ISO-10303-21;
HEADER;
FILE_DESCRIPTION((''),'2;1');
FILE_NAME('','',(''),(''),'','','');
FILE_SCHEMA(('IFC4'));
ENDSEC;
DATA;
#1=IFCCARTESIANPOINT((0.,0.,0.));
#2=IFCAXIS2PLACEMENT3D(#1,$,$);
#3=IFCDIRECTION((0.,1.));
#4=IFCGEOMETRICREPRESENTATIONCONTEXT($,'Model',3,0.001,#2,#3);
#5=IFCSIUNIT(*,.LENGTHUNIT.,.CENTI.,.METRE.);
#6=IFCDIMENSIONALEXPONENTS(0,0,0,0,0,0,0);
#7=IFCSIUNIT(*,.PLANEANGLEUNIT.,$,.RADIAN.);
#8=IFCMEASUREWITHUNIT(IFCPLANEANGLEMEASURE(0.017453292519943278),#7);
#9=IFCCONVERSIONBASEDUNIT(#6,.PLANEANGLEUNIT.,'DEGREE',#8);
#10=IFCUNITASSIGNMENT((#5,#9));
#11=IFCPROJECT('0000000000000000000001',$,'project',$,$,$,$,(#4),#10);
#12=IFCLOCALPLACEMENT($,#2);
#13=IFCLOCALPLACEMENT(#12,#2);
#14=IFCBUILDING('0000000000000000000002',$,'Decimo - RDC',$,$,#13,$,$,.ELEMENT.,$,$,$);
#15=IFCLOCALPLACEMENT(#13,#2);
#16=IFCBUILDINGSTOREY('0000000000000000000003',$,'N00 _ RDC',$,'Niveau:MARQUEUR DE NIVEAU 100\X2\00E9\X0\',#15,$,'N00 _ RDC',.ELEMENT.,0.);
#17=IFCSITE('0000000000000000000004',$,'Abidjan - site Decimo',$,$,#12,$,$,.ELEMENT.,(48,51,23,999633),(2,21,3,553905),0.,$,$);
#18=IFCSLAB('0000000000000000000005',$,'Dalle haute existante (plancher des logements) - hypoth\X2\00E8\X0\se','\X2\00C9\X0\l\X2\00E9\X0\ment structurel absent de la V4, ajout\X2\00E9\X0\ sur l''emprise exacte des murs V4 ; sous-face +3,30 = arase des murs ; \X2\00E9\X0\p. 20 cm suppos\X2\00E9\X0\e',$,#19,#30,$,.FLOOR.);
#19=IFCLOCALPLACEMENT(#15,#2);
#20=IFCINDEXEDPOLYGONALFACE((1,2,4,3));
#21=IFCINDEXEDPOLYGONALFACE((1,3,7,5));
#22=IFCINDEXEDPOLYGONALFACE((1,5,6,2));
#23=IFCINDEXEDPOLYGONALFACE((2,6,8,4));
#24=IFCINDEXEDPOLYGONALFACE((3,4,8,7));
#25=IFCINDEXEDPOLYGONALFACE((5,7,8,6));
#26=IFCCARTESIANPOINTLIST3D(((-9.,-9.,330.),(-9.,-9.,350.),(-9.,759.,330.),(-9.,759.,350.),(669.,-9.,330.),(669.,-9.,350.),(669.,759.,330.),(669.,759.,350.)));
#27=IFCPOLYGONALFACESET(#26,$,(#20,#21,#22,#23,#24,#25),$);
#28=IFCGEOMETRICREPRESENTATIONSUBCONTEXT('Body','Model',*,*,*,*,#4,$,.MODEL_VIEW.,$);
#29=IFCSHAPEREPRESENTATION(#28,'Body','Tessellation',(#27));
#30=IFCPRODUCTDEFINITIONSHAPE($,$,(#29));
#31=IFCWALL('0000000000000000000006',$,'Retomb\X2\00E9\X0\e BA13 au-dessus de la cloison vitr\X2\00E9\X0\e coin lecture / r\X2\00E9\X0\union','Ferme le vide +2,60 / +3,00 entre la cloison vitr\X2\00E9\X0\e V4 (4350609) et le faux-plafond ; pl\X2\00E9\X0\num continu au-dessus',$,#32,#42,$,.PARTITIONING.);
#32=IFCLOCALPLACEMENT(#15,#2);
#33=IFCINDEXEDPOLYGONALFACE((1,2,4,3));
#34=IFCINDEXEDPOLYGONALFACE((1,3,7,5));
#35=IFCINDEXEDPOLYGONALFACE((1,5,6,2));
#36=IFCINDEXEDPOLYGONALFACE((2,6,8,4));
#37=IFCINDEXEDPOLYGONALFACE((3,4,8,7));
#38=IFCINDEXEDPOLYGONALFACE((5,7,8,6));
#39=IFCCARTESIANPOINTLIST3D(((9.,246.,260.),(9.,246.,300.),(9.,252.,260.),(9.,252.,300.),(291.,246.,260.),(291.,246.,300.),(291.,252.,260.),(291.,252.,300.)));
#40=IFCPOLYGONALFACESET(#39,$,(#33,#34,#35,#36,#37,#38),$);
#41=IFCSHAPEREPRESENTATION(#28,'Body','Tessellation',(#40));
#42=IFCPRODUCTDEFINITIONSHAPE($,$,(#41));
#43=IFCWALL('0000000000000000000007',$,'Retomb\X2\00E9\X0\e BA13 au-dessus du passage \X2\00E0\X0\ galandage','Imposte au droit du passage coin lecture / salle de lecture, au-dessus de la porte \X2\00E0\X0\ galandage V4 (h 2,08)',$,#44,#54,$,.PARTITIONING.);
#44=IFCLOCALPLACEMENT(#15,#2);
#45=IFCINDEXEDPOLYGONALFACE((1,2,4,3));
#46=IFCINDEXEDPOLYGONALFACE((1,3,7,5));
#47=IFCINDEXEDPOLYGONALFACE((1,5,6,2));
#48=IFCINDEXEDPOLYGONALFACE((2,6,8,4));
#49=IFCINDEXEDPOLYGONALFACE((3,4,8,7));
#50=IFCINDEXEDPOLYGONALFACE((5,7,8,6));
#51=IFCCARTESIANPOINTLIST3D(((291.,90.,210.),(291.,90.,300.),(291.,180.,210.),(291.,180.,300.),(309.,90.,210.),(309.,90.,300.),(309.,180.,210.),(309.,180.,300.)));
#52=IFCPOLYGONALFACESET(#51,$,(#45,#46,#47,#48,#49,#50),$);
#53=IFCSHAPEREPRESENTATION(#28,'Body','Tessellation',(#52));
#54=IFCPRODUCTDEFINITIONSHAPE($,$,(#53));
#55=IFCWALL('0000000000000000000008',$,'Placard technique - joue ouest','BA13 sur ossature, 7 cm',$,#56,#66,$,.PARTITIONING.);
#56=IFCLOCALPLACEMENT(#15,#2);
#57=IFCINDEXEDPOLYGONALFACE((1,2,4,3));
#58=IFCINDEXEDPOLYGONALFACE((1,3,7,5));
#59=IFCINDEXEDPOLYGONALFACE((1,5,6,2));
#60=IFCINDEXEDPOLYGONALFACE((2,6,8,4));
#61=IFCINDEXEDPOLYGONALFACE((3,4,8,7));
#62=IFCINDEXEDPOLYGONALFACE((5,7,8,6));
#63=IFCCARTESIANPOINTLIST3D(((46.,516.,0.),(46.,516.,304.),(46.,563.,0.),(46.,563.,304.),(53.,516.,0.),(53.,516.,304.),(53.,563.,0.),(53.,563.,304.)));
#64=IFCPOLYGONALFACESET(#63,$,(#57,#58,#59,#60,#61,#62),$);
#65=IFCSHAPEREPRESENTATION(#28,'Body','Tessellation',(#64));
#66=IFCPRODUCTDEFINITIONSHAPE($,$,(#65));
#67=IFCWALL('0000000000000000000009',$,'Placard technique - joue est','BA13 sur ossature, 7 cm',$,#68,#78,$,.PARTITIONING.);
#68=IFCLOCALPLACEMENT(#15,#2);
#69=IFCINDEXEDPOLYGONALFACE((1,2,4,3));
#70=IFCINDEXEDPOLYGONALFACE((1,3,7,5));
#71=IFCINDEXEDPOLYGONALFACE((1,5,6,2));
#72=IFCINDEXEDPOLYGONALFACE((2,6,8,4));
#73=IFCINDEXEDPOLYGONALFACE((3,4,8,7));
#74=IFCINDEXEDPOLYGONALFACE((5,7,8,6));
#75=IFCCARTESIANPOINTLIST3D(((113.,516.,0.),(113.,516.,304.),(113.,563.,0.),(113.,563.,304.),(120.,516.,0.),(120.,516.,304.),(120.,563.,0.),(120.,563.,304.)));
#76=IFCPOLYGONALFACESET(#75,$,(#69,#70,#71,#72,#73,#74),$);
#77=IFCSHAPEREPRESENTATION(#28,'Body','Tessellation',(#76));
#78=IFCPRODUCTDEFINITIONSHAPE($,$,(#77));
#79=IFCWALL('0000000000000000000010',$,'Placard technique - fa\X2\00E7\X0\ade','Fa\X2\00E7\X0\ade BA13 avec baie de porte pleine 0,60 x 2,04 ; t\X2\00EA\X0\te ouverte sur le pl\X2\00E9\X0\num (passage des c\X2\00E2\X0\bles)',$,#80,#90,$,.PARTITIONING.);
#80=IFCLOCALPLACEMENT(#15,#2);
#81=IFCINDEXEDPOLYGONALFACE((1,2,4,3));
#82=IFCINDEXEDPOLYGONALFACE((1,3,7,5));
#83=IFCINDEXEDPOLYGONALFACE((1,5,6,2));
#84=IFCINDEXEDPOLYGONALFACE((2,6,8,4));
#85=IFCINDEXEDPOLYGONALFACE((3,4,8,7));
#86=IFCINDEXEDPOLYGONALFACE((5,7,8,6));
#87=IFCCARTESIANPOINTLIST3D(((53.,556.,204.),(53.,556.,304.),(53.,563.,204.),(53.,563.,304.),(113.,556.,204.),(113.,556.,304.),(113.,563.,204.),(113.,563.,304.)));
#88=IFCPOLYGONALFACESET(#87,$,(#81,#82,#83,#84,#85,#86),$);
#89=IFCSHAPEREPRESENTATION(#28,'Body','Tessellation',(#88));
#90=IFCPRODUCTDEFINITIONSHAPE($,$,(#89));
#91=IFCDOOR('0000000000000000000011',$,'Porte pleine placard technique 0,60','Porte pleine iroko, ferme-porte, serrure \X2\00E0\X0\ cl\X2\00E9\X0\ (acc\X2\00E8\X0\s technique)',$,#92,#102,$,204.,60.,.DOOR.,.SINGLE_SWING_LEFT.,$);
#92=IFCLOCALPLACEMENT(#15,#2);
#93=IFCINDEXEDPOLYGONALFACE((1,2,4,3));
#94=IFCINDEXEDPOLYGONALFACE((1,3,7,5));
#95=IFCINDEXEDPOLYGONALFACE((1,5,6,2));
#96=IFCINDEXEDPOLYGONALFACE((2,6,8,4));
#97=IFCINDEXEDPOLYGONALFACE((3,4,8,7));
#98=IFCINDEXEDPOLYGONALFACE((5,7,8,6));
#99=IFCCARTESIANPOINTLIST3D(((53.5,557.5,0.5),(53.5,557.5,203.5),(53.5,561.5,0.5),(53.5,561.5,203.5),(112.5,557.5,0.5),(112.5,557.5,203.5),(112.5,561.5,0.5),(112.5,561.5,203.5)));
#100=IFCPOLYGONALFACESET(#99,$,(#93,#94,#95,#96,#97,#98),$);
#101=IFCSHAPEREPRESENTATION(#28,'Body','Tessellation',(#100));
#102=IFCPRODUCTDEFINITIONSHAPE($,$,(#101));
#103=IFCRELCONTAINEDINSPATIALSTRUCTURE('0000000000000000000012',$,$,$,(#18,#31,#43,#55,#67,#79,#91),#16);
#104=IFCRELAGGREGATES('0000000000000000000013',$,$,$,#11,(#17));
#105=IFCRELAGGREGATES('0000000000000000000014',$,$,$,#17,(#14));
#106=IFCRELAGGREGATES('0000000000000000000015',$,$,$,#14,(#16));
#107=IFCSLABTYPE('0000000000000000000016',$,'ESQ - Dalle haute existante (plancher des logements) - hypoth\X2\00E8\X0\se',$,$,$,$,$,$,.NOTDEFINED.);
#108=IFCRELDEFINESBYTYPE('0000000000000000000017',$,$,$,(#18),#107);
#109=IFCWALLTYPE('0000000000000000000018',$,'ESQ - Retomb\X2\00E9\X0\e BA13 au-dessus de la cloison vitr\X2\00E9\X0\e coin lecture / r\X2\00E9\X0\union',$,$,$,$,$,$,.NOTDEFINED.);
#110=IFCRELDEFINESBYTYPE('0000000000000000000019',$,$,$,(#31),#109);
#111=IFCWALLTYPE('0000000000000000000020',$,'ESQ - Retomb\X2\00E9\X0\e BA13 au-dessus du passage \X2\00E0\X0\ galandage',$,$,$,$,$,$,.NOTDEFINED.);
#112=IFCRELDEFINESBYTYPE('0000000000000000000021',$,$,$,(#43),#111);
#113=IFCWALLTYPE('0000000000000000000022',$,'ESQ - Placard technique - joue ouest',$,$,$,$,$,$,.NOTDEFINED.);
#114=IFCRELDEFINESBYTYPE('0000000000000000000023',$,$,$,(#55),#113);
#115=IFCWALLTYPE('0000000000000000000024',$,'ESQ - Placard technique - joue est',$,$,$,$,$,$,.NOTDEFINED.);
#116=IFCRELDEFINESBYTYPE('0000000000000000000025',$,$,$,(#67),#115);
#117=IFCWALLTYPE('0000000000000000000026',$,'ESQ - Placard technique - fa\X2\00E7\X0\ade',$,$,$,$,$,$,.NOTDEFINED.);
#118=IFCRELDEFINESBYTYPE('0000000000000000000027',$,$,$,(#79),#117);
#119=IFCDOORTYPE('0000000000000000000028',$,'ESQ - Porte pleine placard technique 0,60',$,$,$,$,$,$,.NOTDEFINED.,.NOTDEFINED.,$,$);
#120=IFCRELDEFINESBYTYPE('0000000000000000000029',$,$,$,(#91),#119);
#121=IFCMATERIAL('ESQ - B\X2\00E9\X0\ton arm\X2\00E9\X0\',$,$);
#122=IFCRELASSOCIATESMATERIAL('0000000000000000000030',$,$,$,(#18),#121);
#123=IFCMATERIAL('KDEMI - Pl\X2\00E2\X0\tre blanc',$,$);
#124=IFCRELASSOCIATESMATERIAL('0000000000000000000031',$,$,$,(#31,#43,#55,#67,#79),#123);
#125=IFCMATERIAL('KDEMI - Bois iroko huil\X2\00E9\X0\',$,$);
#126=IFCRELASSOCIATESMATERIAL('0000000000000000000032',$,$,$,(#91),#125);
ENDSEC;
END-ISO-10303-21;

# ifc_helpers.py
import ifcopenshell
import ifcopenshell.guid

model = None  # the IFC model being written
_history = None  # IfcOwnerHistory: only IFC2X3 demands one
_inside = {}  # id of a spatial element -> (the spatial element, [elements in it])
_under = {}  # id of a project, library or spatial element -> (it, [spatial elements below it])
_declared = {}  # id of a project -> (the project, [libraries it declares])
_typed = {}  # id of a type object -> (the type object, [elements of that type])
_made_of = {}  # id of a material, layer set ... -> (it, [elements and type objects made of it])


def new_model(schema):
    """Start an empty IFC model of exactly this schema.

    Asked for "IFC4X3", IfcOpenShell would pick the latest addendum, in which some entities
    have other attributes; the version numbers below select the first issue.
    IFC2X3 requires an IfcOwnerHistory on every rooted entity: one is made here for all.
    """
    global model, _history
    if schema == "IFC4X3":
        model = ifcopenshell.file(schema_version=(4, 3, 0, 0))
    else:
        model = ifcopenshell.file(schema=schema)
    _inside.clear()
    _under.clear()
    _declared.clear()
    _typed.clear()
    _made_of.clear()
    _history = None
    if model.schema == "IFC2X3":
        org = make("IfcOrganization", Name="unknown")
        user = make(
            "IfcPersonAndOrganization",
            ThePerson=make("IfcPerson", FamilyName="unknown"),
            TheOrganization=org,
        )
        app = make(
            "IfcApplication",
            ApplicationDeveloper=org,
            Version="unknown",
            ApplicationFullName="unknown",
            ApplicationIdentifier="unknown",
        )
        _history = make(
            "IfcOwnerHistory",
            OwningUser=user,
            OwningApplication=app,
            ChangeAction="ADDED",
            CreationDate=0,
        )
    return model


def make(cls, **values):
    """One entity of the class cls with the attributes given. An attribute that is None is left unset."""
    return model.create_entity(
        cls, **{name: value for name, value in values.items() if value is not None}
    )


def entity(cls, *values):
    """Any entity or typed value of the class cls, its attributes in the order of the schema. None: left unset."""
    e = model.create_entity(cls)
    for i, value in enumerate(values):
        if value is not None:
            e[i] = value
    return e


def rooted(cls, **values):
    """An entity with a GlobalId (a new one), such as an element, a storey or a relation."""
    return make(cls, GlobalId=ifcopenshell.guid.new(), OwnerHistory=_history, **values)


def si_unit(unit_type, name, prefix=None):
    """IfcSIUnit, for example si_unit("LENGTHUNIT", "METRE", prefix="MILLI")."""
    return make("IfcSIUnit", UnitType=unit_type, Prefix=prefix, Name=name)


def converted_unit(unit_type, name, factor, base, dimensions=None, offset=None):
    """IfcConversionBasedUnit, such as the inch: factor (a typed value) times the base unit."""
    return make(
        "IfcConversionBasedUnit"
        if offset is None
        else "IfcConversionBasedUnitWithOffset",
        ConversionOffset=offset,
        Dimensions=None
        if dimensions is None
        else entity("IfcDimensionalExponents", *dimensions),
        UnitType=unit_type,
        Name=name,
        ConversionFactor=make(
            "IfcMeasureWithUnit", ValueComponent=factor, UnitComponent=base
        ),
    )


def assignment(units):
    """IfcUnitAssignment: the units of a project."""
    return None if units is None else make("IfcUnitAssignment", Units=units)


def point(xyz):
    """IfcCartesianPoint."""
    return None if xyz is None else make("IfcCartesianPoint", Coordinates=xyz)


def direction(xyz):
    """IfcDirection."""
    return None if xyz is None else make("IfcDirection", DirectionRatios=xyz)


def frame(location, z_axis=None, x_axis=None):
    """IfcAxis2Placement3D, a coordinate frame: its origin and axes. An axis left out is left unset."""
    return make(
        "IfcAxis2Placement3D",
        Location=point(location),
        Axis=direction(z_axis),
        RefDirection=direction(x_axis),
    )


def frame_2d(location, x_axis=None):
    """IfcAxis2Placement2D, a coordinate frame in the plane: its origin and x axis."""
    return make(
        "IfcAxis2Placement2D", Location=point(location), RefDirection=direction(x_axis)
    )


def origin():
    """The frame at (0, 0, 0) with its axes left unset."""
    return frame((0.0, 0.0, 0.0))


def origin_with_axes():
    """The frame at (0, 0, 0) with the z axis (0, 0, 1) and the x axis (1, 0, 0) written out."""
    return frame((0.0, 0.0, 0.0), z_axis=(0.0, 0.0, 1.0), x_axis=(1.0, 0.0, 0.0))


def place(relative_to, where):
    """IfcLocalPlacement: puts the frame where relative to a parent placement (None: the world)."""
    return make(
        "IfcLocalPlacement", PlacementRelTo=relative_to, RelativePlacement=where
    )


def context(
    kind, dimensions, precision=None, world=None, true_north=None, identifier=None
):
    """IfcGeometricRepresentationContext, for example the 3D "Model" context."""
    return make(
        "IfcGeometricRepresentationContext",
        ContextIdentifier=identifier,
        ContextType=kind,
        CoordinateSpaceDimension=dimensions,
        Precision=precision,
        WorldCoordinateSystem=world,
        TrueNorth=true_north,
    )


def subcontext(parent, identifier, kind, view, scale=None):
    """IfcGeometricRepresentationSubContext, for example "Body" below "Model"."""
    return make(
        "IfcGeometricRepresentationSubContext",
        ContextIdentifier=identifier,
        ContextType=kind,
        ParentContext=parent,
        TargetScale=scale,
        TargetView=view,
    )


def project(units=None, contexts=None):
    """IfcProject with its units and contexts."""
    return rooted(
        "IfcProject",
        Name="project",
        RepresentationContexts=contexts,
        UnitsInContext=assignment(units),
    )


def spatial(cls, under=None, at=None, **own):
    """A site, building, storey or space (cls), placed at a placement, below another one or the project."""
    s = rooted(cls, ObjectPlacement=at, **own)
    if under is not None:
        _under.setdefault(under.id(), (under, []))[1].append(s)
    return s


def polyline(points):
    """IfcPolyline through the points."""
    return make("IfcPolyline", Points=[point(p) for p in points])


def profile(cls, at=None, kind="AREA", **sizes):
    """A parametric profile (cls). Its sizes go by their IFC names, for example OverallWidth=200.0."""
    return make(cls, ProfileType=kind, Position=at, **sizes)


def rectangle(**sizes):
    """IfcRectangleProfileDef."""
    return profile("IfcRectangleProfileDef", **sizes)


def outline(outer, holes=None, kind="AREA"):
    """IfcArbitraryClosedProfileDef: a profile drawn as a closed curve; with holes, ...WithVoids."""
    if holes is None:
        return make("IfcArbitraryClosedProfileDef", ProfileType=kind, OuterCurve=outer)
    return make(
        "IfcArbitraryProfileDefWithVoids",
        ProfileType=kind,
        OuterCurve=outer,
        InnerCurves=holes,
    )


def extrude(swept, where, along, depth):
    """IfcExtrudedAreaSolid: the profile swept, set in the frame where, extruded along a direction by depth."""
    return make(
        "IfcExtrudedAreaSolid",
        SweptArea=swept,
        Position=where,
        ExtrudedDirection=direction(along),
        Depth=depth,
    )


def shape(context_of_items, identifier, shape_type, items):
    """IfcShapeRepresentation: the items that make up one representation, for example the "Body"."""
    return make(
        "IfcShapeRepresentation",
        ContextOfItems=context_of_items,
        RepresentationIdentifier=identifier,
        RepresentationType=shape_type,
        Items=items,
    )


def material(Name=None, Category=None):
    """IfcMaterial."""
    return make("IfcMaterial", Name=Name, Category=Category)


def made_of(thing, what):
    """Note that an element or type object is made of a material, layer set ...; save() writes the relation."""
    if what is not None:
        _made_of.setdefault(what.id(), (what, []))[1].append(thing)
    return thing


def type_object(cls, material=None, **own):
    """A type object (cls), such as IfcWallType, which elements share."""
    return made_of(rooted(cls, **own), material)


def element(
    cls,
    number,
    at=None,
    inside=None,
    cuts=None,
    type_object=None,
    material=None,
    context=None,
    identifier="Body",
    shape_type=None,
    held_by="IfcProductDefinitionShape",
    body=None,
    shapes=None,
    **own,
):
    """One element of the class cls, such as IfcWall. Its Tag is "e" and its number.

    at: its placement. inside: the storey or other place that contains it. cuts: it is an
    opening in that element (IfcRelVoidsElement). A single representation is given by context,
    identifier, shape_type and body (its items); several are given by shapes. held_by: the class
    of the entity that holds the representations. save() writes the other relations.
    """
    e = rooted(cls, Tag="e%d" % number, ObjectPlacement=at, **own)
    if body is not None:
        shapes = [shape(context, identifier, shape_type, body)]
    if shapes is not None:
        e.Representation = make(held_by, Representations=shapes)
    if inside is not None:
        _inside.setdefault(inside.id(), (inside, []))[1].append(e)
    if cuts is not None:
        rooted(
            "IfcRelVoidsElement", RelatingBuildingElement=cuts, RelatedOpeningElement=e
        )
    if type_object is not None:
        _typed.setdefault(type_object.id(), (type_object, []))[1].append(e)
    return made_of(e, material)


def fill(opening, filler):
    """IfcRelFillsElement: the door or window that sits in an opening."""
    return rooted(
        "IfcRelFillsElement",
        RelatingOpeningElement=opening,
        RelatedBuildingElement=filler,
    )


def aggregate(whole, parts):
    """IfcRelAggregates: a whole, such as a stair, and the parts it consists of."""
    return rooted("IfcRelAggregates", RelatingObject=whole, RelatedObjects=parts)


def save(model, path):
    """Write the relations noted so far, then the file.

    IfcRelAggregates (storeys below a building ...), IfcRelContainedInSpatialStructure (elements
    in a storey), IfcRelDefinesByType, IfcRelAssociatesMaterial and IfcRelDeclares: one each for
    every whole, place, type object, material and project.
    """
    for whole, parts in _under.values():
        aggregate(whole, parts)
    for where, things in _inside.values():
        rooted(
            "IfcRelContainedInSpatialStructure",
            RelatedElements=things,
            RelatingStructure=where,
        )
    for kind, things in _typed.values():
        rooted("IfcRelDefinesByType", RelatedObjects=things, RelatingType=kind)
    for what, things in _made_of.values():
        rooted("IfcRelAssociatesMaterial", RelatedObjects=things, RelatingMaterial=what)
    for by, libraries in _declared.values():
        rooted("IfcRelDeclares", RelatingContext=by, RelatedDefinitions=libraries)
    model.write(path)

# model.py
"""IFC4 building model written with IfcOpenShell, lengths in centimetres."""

from ifc_helpers import new_model, entity, si_unit, converted_unit, direction, frame, frame_2d, origin, origin_with_axes, place, context, subcontext, project, spatial, polyline, rectangle, outline, extrude, material, type_object, element, fill, save


model = new_model("IFC4")

# Units and contexts
model_context = context("Model", 3, precision=0.001, world=origin(), true_north=direction((0.0, 1.0)))
body_context = subcontext(model_context, "Body", "Model", "MODEL_VIEW")
ifc_project = project(units=[si_unit("LENGTHUNIT", "METRE", prefix="CENTI"), converted_unit("PLANEANGLEUNIT", "DEGREE", entity("IfcPlaneAngleMeasure", 0.017453292519943278), si_unit("PLANEANGLEUNIT", "RADIAN"), dimensions=[0, 0, 0, 0, 0, 0, 0])], contexts=[model_context])

# Site, building, storey
site_placement = place(None, origin())
site = spatial("IfcSite", under=ifc_project, at=site_placement, Name="Abidjan - site Decimo", CompositionType="ELEMENT", RefLatitude=(48, 51, 23, 999633), RefLongitude=(2, 21, 3, 553905), RefElevation=0.0)
building_placement = place(site_placement, origin())
building = spatial("IfcBuilding", under=site, at=building_placement, Name="Decimo - RDC", CompositionType="ELEMENT")
storey_placement = place(building_placement, origin())
storey = spatial("IfcBuildingStorey", under=building, at=storey_placement, Name="N00 _ RDC", ObjectType="Niveau:MARQUEUR DE NIVEAU 100é", LongName="N00 _ RDC", CompositionType="ELEMENT", Elevation=0.0)

# Slab
ifc_material_1 = material(Name="ESQ - Béton armé")
slab_type = type_object("IfcSlabType", Name="ESQ - Dalle haute existante (plancher des logements) - hypothèse", PredefinedType="NOTDEFINED")
slab_placement = place(storey_placement, origin_with_axes())
element("IfcSlab", 1, at=slab_placement, inside=storey, type_object=slab_type, material=ifc_material_1, Name="Dalle haute existante (plancher des logements) - hypothèse", Description="Élément structurel absent de la V4, ajouté sur l'emprise exacte des murs V4 ; sous-face +3,30 = arase des murs ; ép. 20 cm supposée", PredefinedType="FLOOR", context=body_context, shape_type="SweptSolid", body=[
    extrude(outline(polyline([(669.0, -9.0), (-9.0, -9.0), (-9.0, 759.0), (669.0, 759.0), (669.0, -9.0)])), frame((0.0, 0.0, 330.0)), (0.0, 0.0, 1.0), 20.0),
])

# Walls
ifc_material_2 = material(Name="KDEMI - Plâtre blanc")
wall_type_1 = type_object("IfcWallType", Name="ESQ - Retombée BA13 au-dessus de la cloison vitrée coin lecture / réunion", PredefinedType="NOTDEFINED")
wall_1_placement = place(storey_placement, origin_with_axes())
element("IfcWall", 2, at=wall_1_placement, inside=storey, type_object=wall_type_1, material=ifc_material_2, Name="Retombée BA13 au-dessus de la cloison vitrée coin lecture / réunion", Description="Ferme le vide +2,60 / +3,00 entre la cloison vitrée V4 (4350609) et le faux-plafond ; plénum continu au-dessus", PredefinedType="PARTITIONING", context=body_context, shape_type="SweptSolid", body=[
    extrude(rectangle(XDim=282.0, YDim=6.0, at=frame_2d((150.0, 249.0))), frame((0.0, 0.0, 260.0)), (0.0, 0.0, 1.0), 40.0),
])
wall_type_2 = type_object("IfcWallType", Name="ESQ - Retombée BA13 au-dessus du passage à galandage", PredefinedType="NOTDEFINED")
wall_2_placement = place(storey_placement, origin_with_axes())
element("IfcWall", 3, at=wall_2_placement, inside=storey, type_object=wall_type_2, material=ifc_material_2, Name="Retombée BA13 au-dessus du passage à galandage", Description="Imposte au droit du passage coin lecture / salle de lecture, au-dessus de la porte à galandage V4 (h 2,08)", PredefinedType="PARTITIONING", context=body_context, shape_type="SweptSolid", body=[
    extrude(rectangle(XDim=18.0, YDim=90.0, at=frame_2d((300.0, 135.0))), frame((0.0, 0.0, 210.0)), (0.0, 0.0, 1.0), 90.0),
])
wall_type_3 = type_object("IfcWallType", Name="ESQ - Placard technique - joue ouest", PredefinedType="NOTDEFINED")
wall_3_placement = place(storey_placement, origin_with_axes())
element("IfcWall", 4, at=wall_3_placement, inside=storey, type_object=wall_type_3, material=ifc_material_2, Name="Placard technique - joue ouest", Description="BA13 sur ossature, 7 cm", PredefinedType="PARTITIONING", context=body_context, shape_type="SweptSolid", body=[
    extrude(rectangle(XDim=7.0, YDim=47.0, at=frame_2d((49.5, 539.5))), origin(), (0.0, 0.0, 1.0), 304.0),
])
wall_type_4 = type_object("IfcWallType", Name="ESQ - Placard technique - joue est", PredefinedType="NOTDEFINED")
wall_4_placement = place(storey_placement, origin_with_axes())
element("IfcWall", 5, at=wall_4_placement, inside=storey, type_object=wall_type_4, material=ifc_material_2, Name="Placard technique - joue est", Description="BA13 sur ossature, 7 cm", PredefinedType="PARTITIONING", context=body_context, shape_type="SweptSolid", body=[
    extrude(rectangle(XDim=7.0, YDim=47.0, at=frame_2d((116.5, 539.5))), origin(), (0.0, 0.0, 1.0), 304.0),
])

# Wall, opening, door
wall_type_5 = type_object("IfcWallType", Name="ESQ - Placard technique - façade", PredefinedType="NOTDEFINED")
wall_5_placement = place(storey_placement, origin_with_axes())
wall_5 = element("IfcWall", 6, at=wall_5_placement, inside=storey, type_object=wall_type_5, material=ifc_material_2, Name="Placard technique - façade", Description="Façade BA13 avec baie de porte pleine 0,60 x 2,04 ; tête ouverte sur le plénum (passage des câbles)", PredefinedType="PARTITIONING", context=body_context, shape_type="SweptSolid", body=[
    extrude(rectangle(XDim=60.0, YDim=7.0, at=frame_2d((83.0, 559.5))), origin(), (0.0, 0.0, 1.0), 304.0),
])
opening_placement = place(wall_5_placement, origin_with_axes())
opening = element("IfcOpeningElement", 7, at=opening_placement, cuts=wall_5, PredefinedType="OPENING", context=body_context, shape_type="SweptSolid", body=[
    extrude(rectangle(XDim=60.0, YDim=9.0, at=frame_2d((83.0, 559.5))), origin(), (0.0, 0.0, 1.0), 204.0),
])
ifc_material_3 = material(Name="KDEMI - Bois iroko huilé")
door_type = type_object("IfcDoorType", Name="ESQ - Porte pleine placard technique 0,60", OperationType="NOTDEFINED", PredefinedType="NOTDEFINED")
door_placement = place(storey_placement, origin_with_axes())
door = element("IfcDoor", 8, at=door_placement, inside=storey, type_object=door_type, material=ifc_material_3, Name="Porte pleine placard technique 0,60", Description="Porte pleine iroko, ferme-porte, serrure à clé (accès technique)", OperationType="SINGLE_SWING_LEFT", OverallHeight=204.0, OverallWidth=60.0, PredefinedType="DOOR", context=body_context, shape_type="SweptSolid", body=[
    extrude(rectangle(XDim=59.0, YDim=4.0, at=frame_2d((83.0, 559.5))), frame((0.0, 0.0, 0.5)), (0.0, 0.0, 1.0), 203.0),
])
fill(opening, door)

save(model, "model.ifc")
